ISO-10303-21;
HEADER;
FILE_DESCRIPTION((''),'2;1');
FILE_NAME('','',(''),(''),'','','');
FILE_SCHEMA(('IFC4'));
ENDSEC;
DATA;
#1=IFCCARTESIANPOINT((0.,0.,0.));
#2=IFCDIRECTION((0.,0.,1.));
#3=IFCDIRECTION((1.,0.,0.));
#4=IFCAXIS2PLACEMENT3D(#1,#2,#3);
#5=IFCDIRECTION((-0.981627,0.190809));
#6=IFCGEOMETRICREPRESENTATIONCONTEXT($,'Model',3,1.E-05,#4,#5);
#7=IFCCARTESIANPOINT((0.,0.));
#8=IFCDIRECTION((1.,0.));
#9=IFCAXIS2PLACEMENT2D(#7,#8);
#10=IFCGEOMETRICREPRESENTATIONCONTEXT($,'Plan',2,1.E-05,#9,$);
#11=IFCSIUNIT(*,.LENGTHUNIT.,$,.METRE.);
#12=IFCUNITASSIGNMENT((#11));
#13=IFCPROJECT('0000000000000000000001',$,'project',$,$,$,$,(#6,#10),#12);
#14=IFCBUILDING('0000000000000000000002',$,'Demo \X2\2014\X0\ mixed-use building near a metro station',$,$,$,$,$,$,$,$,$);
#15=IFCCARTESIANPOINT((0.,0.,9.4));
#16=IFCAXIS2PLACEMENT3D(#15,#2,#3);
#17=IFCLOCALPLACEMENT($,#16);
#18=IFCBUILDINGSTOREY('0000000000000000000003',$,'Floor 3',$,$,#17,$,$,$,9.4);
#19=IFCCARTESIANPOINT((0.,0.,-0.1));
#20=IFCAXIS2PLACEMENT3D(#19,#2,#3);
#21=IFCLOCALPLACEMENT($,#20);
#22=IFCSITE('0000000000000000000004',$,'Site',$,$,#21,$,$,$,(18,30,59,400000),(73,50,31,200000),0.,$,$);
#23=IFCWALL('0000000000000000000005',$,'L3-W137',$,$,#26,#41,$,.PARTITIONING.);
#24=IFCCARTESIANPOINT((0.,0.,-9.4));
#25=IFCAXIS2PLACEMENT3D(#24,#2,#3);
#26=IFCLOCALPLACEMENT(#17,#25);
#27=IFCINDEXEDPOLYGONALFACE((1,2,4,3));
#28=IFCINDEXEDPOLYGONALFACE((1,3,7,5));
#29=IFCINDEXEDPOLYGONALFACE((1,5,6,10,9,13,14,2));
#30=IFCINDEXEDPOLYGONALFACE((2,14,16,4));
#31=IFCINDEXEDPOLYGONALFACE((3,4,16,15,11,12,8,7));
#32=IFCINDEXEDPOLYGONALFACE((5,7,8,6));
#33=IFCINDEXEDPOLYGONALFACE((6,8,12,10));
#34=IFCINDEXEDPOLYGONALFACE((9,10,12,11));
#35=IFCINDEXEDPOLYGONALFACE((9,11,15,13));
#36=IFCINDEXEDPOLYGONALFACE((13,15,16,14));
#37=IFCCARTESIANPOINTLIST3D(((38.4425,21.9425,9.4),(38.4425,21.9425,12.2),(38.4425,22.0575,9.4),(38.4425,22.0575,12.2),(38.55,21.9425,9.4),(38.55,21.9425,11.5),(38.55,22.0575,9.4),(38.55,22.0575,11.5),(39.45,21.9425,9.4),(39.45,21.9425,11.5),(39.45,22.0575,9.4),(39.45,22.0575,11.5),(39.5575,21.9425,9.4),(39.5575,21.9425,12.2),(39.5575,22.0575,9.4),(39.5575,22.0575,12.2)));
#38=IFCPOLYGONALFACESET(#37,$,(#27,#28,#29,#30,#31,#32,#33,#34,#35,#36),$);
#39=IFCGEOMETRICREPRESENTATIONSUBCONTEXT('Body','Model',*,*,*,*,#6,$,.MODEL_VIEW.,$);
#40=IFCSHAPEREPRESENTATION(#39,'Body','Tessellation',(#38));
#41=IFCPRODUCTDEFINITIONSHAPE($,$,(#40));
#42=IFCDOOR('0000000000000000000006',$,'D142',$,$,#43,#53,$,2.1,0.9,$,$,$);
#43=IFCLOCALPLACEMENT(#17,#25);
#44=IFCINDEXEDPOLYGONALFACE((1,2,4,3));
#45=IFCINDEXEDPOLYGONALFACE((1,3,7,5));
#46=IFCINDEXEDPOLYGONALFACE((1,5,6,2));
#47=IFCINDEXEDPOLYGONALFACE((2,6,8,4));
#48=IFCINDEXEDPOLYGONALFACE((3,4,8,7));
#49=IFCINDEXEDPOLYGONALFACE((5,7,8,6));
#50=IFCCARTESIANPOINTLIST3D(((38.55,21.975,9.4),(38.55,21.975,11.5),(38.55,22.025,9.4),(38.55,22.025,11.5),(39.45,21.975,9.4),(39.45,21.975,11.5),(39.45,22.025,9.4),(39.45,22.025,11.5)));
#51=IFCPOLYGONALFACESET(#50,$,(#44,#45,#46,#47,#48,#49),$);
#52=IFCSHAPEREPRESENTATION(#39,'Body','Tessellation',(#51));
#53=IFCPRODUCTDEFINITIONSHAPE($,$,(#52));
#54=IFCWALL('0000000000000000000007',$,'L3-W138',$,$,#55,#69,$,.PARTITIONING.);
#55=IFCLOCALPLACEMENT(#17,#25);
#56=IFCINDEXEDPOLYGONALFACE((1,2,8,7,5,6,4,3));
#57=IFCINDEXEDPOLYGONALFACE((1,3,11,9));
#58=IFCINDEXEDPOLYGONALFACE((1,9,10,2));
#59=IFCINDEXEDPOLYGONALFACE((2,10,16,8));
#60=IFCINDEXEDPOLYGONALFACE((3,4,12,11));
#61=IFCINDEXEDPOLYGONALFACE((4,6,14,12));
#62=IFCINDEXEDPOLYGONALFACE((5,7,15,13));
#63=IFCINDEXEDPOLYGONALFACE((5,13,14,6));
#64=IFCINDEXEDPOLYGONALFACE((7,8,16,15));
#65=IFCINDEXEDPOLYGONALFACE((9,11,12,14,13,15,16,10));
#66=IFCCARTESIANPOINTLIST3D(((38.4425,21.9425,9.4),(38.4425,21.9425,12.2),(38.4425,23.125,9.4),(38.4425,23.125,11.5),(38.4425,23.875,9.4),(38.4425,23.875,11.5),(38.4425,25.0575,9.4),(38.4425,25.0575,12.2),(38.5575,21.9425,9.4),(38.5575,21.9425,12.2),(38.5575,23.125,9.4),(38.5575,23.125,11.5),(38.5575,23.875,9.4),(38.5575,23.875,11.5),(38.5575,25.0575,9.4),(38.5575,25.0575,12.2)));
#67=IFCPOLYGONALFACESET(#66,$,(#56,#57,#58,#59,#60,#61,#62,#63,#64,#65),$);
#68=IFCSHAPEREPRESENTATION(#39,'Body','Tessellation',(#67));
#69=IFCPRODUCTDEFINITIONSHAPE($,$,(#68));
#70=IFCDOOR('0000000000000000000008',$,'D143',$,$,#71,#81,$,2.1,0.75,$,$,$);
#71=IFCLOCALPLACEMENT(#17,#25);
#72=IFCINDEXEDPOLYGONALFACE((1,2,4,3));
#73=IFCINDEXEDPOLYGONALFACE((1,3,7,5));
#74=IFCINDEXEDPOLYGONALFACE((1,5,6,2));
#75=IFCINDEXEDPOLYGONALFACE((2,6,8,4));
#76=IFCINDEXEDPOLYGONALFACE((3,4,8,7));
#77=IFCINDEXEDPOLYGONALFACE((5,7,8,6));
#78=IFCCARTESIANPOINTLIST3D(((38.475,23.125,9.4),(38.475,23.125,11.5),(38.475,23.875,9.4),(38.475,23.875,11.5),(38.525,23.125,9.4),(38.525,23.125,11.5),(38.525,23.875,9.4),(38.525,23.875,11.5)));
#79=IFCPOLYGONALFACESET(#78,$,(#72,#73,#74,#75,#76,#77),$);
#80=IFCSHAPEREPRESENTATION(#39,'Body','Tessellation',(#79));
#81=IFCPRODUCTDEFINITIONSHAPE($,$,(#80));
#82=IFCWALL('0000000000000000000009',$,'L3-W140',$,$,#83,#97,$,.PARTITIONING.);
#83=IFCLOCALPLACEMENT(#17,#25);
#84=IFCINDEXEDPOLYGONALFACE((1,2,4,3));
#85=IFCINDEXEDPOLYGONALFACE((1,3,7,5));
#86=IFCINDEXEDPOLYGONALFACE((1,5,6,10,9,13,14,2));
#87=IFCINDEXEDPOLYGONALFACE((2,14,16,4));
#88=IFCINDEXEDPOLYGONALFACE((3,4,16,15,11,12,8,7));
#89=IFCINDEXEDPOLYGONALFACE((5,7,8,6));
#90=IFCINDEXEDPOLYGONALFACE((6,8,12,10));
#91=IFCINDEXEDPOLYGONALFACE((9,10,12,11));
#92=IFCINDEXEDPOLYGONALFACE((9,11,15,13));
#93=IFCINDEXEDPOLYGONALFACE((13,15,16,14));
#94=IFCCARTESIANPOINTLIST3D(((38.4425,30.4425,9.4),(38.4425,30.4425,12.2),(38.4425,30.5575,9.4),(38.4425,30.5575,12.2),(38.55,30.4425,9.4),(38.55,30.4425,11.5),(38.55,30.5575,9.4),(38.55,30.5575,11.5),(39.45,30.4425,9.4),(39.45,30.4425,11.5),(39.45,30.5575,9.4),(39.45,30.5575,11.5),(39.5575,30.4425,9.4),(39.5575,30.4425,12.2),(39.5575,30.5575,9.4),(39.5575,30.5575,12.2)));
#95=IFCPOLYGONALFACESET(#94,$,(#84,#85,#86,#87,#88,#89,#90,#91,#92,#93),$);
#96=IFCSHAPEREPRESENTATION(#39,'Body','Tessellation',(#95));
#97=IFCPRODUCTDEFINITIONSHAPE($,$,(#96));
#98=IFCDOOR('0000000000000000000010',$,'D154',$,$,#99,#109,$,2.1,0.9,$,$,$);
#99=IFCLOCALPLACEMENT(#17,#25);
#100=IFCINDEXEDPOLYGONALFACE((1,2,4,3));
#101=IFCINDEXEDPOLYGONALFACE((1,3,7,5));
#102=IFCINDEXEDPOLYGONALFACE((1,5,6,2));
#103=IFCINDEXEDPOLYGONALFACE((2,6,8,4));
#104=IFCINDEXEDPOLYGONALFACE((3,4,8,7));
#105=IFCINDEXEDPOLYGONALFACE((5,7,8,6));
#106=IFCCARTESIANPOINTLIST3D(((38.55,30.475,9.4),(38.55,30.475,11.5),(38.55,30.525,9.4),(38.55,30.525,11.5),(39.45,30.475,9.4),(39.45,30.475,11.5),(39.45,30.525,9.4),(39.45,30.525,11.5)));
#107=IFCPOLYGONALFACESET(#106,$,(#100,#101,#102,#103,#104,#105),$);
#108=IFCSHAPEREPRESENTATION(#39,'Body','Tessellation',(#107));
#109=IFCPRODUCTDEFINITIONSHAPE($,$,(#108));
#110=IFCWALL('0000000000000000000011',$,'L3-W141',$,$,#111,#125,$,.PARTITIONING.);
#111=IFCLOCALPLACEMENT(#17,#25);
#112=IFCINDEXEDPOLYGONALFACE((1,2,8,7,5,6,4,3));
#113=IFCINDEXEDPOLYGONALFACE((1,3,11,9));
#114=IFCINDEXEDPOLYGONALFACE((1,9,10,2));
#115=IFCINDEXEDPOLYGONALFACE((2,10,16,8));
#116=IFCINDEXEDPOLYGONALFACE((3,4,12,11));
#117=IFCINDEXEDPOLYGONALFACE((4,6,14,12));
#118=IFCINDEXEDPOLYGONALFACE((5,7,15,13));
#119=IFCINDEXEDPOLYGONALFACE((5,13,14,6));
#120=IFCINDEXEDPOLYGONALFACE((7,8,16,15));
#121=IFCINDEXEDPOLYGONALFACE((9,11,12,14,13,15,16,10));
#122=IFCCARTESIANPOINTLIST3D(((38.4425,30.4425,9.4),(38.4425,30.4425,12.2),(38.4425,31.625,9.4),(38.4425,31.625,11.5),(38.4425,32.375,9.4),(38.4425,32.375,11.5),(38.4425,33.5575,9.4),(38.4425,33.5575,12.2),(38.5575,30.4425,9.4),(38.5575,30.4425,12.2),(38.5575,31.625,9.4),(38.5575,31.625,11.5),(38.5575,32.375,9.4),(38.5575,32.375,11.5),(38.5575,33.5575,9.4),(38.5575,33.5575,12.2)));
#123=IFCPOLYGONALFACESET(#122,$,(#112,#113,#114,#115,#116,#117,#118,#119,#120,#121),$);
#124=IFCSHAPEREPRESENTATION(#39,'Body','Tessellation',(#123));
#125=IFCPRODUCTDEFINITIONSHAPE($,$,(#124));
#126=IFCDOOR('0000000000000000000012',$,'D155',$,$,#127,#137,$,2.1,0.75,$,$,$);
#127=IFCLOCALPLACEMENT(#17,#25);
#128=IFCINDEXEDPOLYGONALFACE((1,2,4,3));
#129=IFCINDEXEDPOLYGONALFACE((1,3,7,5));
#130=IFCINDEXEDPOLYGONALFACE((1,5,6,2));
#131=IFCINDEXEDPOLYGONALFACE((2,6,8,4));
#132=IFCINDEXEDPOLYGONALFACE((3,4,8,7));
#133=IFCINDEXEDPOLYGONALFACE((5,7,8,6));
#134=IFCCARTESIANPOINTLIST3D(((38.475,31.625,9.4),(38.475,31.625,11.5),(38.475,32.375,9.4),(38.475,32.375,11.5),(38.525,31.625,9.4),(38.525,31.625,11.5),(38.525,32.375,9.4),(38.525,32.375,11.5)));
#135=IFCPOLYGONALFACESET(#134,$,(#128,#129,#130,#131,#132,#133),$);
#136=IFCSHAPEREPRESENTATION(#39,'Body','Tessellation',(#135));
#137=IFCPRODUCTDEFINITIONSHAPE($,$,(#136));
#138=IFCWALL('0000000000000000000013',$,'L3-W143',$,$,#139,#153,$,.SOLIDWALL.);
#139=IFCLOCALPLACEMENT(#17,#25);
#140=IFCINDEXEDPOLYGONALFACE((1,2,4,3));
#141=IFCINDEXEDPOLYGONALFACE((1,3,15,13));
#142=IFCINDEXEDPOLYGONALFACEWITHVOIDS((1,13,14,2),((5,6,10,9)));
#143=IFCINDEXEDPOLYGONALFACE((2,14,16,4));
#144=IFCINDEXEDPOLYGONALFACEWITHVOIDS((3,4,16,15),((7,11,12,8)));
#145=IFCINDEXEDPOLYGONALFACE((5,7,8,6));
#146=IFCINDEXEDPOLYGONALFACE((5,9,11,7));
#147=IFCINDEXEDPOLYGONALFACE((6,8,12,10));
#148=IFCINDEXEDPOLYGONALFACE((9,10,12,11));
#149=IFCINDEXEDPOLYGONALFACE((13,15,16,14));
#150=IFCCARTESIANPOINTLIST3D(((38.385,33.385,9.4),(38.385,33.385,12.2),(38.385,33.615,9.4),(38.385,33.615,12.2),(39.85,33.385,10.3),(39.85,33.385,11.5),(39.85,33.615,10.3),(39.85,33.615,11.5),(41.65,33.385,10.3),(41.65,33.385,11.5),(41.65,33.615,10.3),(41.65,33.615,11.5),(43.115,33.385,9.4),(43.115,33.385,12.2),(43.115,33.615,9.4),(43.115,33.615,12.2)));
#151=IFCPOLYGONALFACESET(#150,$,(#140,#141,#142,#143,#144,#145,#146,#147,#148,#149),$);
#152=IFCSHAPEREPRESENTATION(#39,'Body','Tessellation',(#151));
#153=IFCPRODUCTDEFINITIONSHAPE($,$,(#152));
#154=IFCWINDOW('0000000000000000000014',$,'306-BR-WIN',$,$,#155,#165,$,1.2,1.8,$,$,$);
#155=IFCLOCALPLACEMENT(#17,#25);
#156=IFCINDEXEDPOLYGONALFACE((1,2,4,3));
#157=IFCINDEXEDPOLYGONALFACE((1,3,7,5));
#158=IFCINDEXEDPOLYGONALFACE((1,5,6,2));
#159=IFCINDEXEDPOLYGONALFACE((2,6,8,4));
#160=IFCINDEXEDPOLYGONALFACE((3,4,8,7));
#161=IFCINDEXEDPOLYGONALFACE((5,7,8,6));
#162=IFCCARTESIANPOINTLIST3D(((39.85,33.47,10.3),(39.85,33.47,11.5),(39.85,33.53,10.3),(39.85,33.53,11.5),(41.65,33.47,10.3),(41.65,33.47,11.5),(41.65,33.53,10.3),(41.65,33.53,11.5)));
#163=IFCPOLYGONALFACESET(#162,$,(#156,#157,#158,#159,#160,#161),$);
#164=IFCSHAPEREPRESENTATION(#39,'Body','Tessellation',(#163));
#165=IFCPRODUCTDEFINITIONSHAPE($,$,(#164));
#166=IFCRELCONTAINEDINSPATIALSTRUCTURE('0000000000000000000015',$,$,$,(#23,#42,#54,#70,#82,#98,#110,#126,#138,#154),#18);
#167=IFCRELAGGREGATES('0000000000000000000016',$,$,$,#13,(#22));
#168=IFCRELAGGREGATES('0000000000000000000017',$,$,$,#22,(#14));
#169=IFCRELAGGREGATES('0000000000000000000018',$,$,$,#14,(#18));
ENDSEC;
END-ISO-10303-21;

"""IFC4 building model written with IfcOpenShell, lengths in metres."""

from ifc_helpers import new_model, si_unit, direction, frame, origin_with_axes, origin_2d_with_axis, place, context, subcontext, project, spatial, line, indexed_curve, outline, extrude, element, fill, save


model = new_model("IFC4")

# Units and contexts
model_context = context("Model", 3, precision=1e-05, world=origin_with_axes(), true_north=direction((-0.981627, 0.190809)))
plan_context = context("Plan", 2, precision=1e-05, world=origin_2d_with_axis())
body_context = subcontext(model_context, "Body", "Model", "MODEL_VIEW")
ifc_project = project(units=[si_unit("LENGTHUNIT", "METRE")], contexts=[model_context, plan_context])

# Site, building, storey
site_placement = place(None, frame((0.0, 0.0, -0.1), z_axis=(0.0, 0.0, 1.0), x_axis=(1.0, 0.0, 0.0)))
site = spatial("IfcSite", under=ifc_project, at=site_placement, Name="Site", RefLatitude=(18, 30, 59, 400000), RefLongitude=(73, 50, 31, 200000), RefElevation=0.0)
building = spatial("IfcBuilding", under=site, Name="Demo — mixed-use building near a metro station")
storey_placement = place(None, frame((0.0, 0.0, 9.4), z_axis=(0.0, 0.0, 1.0), x_axis=(1.0, 0.0, 0.0)))
storey = spatial("IfcBuildingStorey", under=building, at=storey_placement, Name="Floor 3", Elevation=9.4)

# Walls, openings, doors
wall_1_placement = place(storey_placement, frame((0.0, 0.0, -9.4), z_axis=(0.0, 0.0, 1.0), x_axis=(1.0, 0.0, 0.0)))
wall_1 = element("IfcWall", 1, at=wall_1_placement, inside=storey, Name="L3-W137", PredefinedType="PARTITIONING", context=body_context, shape_type="SweptSolid", body=[
    extrude(outline(indexed_curve([(39.5575, 21.9425), (38.4425, 21.9425), (38.4425, 22.0575), (39.5575, 22.0575)], segments=[line(1, 2, 3, 4, 1)])), frame((0.0, 0.0, 9.4), z_axis=(0.0, 0.0, 1.0), x_axis=(1.0, 0.0, 0.0)), (0.0, 0.0, 1.0), 2.8),
])
opening_1_placement = place(wall_1_placement, origin_with_axes())
opening_1 = element("IfcOpeningElement", 2, at=opening_1_placement, cuts=wall_1, context=body_context, shape_type="SweptSolid", body=[
    extrude(outline(indexed_curve([(39.45, 21.8925), (38.55, 21.8925), (38.55, 22.1075), (39.45, 22.1075)], segments=[line(1, 2, 3, 4, 1)])), frame((0.0, 0.0, 9.4), z_axis=(0.0, 0.0, 1.0), x_axis=(1.0, 0.0, 0.0)), (0.0, 0.0, 1.0), 2.1),
])
door_1_placement = place(storey_placement, frame((0.0, 0.0, -9.4), z_axis=(0.0, 0.0, 1.0), x_axis=(1.0, 0.0, 0.0)))
door_1 = element("IfcDoor", 3, at=door_1_placement, inside=storey, Name="D142", OverallHeight=2.1, OverallWidth=0.9, context=body_context, shape_type="SweptSolid", body=[
    extrude(outline(indexed_curve([(39.45, 21.975), (38.55, 21.975), (38.55, 22.025), (39.45, 22.025)], segments=[line(1, 2, 3, 4, 1)])), frame((0.0, 0.0, 9.4), z_axis=(0.0, 0.0, 1.0), x_axis=(1.0, 0.0, 0.0)), (0.0, 0.0, 1.0), 2.1),
])
fill(opening_1, door_1)
wall_2_placement = place(storey_placement, frame((0.0, 0.0, -9.4), z_axis=(0.0, 0.0, 1.0), x_axis=(1.0, 0.0, 0.0)))
wall_2 = element("IfcWall", 4, at=wall_2_placement, inside=storey, Name="L3-W138", PredefinedType="PARTITIONING", context=body_context, shape_type="SweptSolid", body=[
    extrude(outline(indexed_curve([(38.5575, 25.0575), (38.5575, 21.9425), (38.4425, 21.9425), (38.4425, 25.0575)], segments=[line(1, 2, 3, 4, 1)])), frame((0.0, 0.0, 9.4), z_axis=(0.0, 0.0, 1.0), x_axis=(1.0, 0.0, 0.0)), (0.0, 0.0, 1.0), 2.8),
])
opening_2_placement = place(wall_2_placement, origin_with_axes())
opening_2 = element("IfcOpeningElement", 5, at=opening_2_placement, cuts=wall_2, context=body_context, shape_type="SweptSolid", body=[
    extrude(outline(indexed_curve([(38.6075, 23.875), (38.6075, 23.125), (38.3925, 23.125), (38.3925, 23.875)], segments=[line(1, 2, 3, 4, 1)])), frame((0.0, 0.0, 9.4), z_axis=(0.0, 0.0, 1.0), x_axis=(1.0, 0.0, 0.0)), (0.0, 0.0, 1.0), 2.1),
])
door_2_placement = place(storey_placement, frame((0.0, 0.0, -9.4), z_axis=(0.0, 0.0, 1.0), x_axis=(1.0, 0.0, 0.0)))
door_2 = element("IfcDoor", 6, at=door_2_placement, inside=storey, Name="D143", OverallHeight=2.1, OverallWidth=0.75, context=body_context, shape_type="SweptSolid", body=[
    extrude(outline(indexed_curve([(38.525, 23.875), (38.525, 23.125), (38.475, 23.125), (38.475, 23.875)], segments=[line(1, 2, 3, 4, 1)])), frame((0.0, 0.0, 9.4), z_axis=(0.0, 0.0, 1.0), x_axis=(1.0, 0.0, 0.0)), (0.0, 0.0, 1.0), 2.1),
])
fill(opening_2, door_2)

# Walls, openings, doors
wall_3_placement = place(storey_placement, frame((0.0, 0.0, -9.4), z_axis=(0.0, 0.0, 1.0), x_axis=(1.0, 0.0, 0.0)))
wall_3 = element("IfcWall", 7, at=wall_3_placement, inside=storey, Name="L3-W140", PredefinedType="PARTITIONING", context=body_context, shape_type="SweptSolid", body=[
    extrude(outline(indexed_curve([(39.5575, 30.4425), (38.4425, 30.4425), (38.4425, 30.5575), (39.5575, 30.5575)], segments=[line(1, 2, 3, 4, 1)])), frame((0.0, 0.0, 9.4), z_axis=(0.0, 0.0, 1.0), x_axis=(1.0, 0.0, 0.0)), (0.0, 0.0, 1.0), 2.8),
])
opening_3_placement = place(wall_3_placement, origin_with_axes())
opening_3 = element("IfcOpeningElement", 8, at=opening_3_placement, cuts=wall_3, context=body_context, shape_type="SweptSolid", body=[
    extrude(outline(indexed_curve([(39.45, 30.3925), (38.55, 30.3925), (38.55, 30.6075), (39.45, 30.6075)], segments=[line(1, 2, 3, 4, 1)])), frame((0.0, 0.0, 9.4), z_axis=(0.0, 0.0, 1.0), x_axis=(1.0, 0.0, 0.0)), (0.0, 0.0, 1.0), 2.1),
])
door_3_placement = place(storey_placement, frame((0.0, 0.0, -9.4), z_axis=(0.0, 0.0, 1.0), x_axis=(1.0, 0.0, 0.0)))
door_3 = element("IfcDoor", 9, at=door_3_placement, inside=storey, Name="D154", OverallHeight=2.1, OverallWidth=0.9, context=body_context, shape_type="SweptSolid", body=[
    extrude(outline(indexed_curve([(39.45, 30.475), (38.55, 30.475), (38.55, 30.525), (39.45, 30.525)], segments=[line(1, 2, 3, 4, 1)])), frame((0.0, 0.0, 9.4), z_axis=(0.0, 0.0, 1.0), x_axis=(1.0, 0.0, 0.0)), (0.0, 0.0, 1.0), 2.1),
])
fill(opening_3, door_3)
wall_4_placement = place(storey_placement, frame((0.0, 0.0, -9.4), z_axis=(0.0, 0.0, 1.0), x_axis=(1.0, 0.0, 0.0)))
wall_4 = element("IfcWall", 10, at=wall_4_placement, inside=storey, Name="L3-W141", PredefinedType="PARTITIONING", context=body_context, shape_type="SweptSolid", body=[
    extrude(outline(indexed_curve([(38.5575, 33.5575), (38.5575, 30.4425), (38.4425, 30.4425), (38.4425, 33.5575)], segments=[line(1, 2, 3, 4, 1)])), frame((0.0, 0.0, 9.4), z_axis=(0.0, 0.0, 1.0), x_axis=(1.0, 0.0, 0.0)), (0.0, 0.0, 1.0), 2.8),
])
opening_4_placement = place(wall_4_placement, origin_with_axes())
opening_4 = element("IfcOpeningElement", 11, at=opening_4_placement, cuts=wall_4, context=body_context, shape_type="SweptSolid", body=[
    extrude(outline(indexed_curve([(38.6075, 32.375), (38.6075, 31.625), (38.3925, 31.625), (38.3925, 32.375)], segments=[line(1, 2, 3, 4, 1)])), frame((0.0, 0.0, 9.4), z_axis=(0.0, 0.0, 1.0), x_axis=(1.0, 0.0, 0.0)), (0.0, 0.0, 1.0), 2.1),
])
door_4_placement = place(storey_placement, frame((0.0, 0.0, -9.4), z_axis=(0.0, 0.0, 1.0), x_axis=(1.0, 0.0, 0.0)))
door_4 = element("IfcDoor", 12, at=door_4_placement, inside=storey, Name="D155", OverallHeight=2.1, OverallWidth=0.75, context=body_context, shape_type="SweptSolid", body=[
    extrude(outline(indexed_curve([(38.525, 32.375), (38.525, 31.625), (38.475, 31.625), (38.475, 32.375)], segments=[line(1, 2, 3, 4, 1)])), frame((0.0, 0.0, 9.4), z_axis=(0.0, 0.0, 1.0), x_axis=(1.0, 0.0, 0.0)), (0.0, 0.0, 1.0), 2.1),
])
fill(opening_4, door_4)

# Wall, opening, window
wall_5_placement = place(storey_placement, frame((0.0, 0.0, -9.4), z_axis=(0.0, 0.0, 1.0), x_axis=(1.0, 0.0, 0.0)))
wall_5 = element("IfcWall", 13, at=wall_5_placement, inside=storey, Name="L3-W143", PredefinedType="SOLIDWALL", context=body_context, shape_type="SweptSolid", body=[
    extrude(outline(indexed_curve([(43.115, 33.385), (38.385, 33.385), (38.385, 33.615), (43.115, 33.615)], segments=[line(1, 2, 3, 4, 1)])), frame((0.0, 0.0, 9.4), z_axis=(0.0, 0.0, 1.0), x_axis=(1.0, 0.0, 0.0)), (0.0, 0.0, 1.0), 2.8),
])
opening_5_placement = place(wall_5_placement, origin_with_axes())
opening_5 = element("IfcOpeningElement", 14, at=opening_5_placement, cuts=wall_5, context=body_context, shape_type="SweptSolid", body=[
    extrude(outline(indexed_curve([(41.65, 33.335), (39.85, 33.335), (39.85, 33.665), (41.65, 33.665)], segments=[line(1, 2, 3, 4, 1)])), frame((0.0, 0.0, 10.3), z_axis=(0.0, 0.0, 1.0), x_axis=(1.0, 0.0, 0.0)), (0.0, 0.0, 1.0), 1.2),
])
window_1_placement = place(storey_placement, frame((0.0, 0.0, -9.4), z_axis=(0.0, 0.0, 1.0), x_axis=(1.0, 0.0, 0.0)))
window_1 = element("IfcWindow", 15, at=window_1_placement, inside=storey, Name="306-BR-WIN", OverallHeight=1.2, OverallWidth=1.8, context=body_context, shape_type="SweptSolid", body=[
    extrude(outline(indexed_curve([(41.65, 33.47), (39.85, 33.47), (39.85, 33.53), (41.65, 33.53)], segments=[line(1, 2, 3, 4, 1)])), frame((0.0, 0.0, 10.3), z_axis=(0.0, 0.0, 1.0), x_axis=(1.0, 0.0, 0.0)), (0.0, 0.0, 1.0), 1.2),
])
fill(opening_5, window_1)

save(model, "model.ifc")
